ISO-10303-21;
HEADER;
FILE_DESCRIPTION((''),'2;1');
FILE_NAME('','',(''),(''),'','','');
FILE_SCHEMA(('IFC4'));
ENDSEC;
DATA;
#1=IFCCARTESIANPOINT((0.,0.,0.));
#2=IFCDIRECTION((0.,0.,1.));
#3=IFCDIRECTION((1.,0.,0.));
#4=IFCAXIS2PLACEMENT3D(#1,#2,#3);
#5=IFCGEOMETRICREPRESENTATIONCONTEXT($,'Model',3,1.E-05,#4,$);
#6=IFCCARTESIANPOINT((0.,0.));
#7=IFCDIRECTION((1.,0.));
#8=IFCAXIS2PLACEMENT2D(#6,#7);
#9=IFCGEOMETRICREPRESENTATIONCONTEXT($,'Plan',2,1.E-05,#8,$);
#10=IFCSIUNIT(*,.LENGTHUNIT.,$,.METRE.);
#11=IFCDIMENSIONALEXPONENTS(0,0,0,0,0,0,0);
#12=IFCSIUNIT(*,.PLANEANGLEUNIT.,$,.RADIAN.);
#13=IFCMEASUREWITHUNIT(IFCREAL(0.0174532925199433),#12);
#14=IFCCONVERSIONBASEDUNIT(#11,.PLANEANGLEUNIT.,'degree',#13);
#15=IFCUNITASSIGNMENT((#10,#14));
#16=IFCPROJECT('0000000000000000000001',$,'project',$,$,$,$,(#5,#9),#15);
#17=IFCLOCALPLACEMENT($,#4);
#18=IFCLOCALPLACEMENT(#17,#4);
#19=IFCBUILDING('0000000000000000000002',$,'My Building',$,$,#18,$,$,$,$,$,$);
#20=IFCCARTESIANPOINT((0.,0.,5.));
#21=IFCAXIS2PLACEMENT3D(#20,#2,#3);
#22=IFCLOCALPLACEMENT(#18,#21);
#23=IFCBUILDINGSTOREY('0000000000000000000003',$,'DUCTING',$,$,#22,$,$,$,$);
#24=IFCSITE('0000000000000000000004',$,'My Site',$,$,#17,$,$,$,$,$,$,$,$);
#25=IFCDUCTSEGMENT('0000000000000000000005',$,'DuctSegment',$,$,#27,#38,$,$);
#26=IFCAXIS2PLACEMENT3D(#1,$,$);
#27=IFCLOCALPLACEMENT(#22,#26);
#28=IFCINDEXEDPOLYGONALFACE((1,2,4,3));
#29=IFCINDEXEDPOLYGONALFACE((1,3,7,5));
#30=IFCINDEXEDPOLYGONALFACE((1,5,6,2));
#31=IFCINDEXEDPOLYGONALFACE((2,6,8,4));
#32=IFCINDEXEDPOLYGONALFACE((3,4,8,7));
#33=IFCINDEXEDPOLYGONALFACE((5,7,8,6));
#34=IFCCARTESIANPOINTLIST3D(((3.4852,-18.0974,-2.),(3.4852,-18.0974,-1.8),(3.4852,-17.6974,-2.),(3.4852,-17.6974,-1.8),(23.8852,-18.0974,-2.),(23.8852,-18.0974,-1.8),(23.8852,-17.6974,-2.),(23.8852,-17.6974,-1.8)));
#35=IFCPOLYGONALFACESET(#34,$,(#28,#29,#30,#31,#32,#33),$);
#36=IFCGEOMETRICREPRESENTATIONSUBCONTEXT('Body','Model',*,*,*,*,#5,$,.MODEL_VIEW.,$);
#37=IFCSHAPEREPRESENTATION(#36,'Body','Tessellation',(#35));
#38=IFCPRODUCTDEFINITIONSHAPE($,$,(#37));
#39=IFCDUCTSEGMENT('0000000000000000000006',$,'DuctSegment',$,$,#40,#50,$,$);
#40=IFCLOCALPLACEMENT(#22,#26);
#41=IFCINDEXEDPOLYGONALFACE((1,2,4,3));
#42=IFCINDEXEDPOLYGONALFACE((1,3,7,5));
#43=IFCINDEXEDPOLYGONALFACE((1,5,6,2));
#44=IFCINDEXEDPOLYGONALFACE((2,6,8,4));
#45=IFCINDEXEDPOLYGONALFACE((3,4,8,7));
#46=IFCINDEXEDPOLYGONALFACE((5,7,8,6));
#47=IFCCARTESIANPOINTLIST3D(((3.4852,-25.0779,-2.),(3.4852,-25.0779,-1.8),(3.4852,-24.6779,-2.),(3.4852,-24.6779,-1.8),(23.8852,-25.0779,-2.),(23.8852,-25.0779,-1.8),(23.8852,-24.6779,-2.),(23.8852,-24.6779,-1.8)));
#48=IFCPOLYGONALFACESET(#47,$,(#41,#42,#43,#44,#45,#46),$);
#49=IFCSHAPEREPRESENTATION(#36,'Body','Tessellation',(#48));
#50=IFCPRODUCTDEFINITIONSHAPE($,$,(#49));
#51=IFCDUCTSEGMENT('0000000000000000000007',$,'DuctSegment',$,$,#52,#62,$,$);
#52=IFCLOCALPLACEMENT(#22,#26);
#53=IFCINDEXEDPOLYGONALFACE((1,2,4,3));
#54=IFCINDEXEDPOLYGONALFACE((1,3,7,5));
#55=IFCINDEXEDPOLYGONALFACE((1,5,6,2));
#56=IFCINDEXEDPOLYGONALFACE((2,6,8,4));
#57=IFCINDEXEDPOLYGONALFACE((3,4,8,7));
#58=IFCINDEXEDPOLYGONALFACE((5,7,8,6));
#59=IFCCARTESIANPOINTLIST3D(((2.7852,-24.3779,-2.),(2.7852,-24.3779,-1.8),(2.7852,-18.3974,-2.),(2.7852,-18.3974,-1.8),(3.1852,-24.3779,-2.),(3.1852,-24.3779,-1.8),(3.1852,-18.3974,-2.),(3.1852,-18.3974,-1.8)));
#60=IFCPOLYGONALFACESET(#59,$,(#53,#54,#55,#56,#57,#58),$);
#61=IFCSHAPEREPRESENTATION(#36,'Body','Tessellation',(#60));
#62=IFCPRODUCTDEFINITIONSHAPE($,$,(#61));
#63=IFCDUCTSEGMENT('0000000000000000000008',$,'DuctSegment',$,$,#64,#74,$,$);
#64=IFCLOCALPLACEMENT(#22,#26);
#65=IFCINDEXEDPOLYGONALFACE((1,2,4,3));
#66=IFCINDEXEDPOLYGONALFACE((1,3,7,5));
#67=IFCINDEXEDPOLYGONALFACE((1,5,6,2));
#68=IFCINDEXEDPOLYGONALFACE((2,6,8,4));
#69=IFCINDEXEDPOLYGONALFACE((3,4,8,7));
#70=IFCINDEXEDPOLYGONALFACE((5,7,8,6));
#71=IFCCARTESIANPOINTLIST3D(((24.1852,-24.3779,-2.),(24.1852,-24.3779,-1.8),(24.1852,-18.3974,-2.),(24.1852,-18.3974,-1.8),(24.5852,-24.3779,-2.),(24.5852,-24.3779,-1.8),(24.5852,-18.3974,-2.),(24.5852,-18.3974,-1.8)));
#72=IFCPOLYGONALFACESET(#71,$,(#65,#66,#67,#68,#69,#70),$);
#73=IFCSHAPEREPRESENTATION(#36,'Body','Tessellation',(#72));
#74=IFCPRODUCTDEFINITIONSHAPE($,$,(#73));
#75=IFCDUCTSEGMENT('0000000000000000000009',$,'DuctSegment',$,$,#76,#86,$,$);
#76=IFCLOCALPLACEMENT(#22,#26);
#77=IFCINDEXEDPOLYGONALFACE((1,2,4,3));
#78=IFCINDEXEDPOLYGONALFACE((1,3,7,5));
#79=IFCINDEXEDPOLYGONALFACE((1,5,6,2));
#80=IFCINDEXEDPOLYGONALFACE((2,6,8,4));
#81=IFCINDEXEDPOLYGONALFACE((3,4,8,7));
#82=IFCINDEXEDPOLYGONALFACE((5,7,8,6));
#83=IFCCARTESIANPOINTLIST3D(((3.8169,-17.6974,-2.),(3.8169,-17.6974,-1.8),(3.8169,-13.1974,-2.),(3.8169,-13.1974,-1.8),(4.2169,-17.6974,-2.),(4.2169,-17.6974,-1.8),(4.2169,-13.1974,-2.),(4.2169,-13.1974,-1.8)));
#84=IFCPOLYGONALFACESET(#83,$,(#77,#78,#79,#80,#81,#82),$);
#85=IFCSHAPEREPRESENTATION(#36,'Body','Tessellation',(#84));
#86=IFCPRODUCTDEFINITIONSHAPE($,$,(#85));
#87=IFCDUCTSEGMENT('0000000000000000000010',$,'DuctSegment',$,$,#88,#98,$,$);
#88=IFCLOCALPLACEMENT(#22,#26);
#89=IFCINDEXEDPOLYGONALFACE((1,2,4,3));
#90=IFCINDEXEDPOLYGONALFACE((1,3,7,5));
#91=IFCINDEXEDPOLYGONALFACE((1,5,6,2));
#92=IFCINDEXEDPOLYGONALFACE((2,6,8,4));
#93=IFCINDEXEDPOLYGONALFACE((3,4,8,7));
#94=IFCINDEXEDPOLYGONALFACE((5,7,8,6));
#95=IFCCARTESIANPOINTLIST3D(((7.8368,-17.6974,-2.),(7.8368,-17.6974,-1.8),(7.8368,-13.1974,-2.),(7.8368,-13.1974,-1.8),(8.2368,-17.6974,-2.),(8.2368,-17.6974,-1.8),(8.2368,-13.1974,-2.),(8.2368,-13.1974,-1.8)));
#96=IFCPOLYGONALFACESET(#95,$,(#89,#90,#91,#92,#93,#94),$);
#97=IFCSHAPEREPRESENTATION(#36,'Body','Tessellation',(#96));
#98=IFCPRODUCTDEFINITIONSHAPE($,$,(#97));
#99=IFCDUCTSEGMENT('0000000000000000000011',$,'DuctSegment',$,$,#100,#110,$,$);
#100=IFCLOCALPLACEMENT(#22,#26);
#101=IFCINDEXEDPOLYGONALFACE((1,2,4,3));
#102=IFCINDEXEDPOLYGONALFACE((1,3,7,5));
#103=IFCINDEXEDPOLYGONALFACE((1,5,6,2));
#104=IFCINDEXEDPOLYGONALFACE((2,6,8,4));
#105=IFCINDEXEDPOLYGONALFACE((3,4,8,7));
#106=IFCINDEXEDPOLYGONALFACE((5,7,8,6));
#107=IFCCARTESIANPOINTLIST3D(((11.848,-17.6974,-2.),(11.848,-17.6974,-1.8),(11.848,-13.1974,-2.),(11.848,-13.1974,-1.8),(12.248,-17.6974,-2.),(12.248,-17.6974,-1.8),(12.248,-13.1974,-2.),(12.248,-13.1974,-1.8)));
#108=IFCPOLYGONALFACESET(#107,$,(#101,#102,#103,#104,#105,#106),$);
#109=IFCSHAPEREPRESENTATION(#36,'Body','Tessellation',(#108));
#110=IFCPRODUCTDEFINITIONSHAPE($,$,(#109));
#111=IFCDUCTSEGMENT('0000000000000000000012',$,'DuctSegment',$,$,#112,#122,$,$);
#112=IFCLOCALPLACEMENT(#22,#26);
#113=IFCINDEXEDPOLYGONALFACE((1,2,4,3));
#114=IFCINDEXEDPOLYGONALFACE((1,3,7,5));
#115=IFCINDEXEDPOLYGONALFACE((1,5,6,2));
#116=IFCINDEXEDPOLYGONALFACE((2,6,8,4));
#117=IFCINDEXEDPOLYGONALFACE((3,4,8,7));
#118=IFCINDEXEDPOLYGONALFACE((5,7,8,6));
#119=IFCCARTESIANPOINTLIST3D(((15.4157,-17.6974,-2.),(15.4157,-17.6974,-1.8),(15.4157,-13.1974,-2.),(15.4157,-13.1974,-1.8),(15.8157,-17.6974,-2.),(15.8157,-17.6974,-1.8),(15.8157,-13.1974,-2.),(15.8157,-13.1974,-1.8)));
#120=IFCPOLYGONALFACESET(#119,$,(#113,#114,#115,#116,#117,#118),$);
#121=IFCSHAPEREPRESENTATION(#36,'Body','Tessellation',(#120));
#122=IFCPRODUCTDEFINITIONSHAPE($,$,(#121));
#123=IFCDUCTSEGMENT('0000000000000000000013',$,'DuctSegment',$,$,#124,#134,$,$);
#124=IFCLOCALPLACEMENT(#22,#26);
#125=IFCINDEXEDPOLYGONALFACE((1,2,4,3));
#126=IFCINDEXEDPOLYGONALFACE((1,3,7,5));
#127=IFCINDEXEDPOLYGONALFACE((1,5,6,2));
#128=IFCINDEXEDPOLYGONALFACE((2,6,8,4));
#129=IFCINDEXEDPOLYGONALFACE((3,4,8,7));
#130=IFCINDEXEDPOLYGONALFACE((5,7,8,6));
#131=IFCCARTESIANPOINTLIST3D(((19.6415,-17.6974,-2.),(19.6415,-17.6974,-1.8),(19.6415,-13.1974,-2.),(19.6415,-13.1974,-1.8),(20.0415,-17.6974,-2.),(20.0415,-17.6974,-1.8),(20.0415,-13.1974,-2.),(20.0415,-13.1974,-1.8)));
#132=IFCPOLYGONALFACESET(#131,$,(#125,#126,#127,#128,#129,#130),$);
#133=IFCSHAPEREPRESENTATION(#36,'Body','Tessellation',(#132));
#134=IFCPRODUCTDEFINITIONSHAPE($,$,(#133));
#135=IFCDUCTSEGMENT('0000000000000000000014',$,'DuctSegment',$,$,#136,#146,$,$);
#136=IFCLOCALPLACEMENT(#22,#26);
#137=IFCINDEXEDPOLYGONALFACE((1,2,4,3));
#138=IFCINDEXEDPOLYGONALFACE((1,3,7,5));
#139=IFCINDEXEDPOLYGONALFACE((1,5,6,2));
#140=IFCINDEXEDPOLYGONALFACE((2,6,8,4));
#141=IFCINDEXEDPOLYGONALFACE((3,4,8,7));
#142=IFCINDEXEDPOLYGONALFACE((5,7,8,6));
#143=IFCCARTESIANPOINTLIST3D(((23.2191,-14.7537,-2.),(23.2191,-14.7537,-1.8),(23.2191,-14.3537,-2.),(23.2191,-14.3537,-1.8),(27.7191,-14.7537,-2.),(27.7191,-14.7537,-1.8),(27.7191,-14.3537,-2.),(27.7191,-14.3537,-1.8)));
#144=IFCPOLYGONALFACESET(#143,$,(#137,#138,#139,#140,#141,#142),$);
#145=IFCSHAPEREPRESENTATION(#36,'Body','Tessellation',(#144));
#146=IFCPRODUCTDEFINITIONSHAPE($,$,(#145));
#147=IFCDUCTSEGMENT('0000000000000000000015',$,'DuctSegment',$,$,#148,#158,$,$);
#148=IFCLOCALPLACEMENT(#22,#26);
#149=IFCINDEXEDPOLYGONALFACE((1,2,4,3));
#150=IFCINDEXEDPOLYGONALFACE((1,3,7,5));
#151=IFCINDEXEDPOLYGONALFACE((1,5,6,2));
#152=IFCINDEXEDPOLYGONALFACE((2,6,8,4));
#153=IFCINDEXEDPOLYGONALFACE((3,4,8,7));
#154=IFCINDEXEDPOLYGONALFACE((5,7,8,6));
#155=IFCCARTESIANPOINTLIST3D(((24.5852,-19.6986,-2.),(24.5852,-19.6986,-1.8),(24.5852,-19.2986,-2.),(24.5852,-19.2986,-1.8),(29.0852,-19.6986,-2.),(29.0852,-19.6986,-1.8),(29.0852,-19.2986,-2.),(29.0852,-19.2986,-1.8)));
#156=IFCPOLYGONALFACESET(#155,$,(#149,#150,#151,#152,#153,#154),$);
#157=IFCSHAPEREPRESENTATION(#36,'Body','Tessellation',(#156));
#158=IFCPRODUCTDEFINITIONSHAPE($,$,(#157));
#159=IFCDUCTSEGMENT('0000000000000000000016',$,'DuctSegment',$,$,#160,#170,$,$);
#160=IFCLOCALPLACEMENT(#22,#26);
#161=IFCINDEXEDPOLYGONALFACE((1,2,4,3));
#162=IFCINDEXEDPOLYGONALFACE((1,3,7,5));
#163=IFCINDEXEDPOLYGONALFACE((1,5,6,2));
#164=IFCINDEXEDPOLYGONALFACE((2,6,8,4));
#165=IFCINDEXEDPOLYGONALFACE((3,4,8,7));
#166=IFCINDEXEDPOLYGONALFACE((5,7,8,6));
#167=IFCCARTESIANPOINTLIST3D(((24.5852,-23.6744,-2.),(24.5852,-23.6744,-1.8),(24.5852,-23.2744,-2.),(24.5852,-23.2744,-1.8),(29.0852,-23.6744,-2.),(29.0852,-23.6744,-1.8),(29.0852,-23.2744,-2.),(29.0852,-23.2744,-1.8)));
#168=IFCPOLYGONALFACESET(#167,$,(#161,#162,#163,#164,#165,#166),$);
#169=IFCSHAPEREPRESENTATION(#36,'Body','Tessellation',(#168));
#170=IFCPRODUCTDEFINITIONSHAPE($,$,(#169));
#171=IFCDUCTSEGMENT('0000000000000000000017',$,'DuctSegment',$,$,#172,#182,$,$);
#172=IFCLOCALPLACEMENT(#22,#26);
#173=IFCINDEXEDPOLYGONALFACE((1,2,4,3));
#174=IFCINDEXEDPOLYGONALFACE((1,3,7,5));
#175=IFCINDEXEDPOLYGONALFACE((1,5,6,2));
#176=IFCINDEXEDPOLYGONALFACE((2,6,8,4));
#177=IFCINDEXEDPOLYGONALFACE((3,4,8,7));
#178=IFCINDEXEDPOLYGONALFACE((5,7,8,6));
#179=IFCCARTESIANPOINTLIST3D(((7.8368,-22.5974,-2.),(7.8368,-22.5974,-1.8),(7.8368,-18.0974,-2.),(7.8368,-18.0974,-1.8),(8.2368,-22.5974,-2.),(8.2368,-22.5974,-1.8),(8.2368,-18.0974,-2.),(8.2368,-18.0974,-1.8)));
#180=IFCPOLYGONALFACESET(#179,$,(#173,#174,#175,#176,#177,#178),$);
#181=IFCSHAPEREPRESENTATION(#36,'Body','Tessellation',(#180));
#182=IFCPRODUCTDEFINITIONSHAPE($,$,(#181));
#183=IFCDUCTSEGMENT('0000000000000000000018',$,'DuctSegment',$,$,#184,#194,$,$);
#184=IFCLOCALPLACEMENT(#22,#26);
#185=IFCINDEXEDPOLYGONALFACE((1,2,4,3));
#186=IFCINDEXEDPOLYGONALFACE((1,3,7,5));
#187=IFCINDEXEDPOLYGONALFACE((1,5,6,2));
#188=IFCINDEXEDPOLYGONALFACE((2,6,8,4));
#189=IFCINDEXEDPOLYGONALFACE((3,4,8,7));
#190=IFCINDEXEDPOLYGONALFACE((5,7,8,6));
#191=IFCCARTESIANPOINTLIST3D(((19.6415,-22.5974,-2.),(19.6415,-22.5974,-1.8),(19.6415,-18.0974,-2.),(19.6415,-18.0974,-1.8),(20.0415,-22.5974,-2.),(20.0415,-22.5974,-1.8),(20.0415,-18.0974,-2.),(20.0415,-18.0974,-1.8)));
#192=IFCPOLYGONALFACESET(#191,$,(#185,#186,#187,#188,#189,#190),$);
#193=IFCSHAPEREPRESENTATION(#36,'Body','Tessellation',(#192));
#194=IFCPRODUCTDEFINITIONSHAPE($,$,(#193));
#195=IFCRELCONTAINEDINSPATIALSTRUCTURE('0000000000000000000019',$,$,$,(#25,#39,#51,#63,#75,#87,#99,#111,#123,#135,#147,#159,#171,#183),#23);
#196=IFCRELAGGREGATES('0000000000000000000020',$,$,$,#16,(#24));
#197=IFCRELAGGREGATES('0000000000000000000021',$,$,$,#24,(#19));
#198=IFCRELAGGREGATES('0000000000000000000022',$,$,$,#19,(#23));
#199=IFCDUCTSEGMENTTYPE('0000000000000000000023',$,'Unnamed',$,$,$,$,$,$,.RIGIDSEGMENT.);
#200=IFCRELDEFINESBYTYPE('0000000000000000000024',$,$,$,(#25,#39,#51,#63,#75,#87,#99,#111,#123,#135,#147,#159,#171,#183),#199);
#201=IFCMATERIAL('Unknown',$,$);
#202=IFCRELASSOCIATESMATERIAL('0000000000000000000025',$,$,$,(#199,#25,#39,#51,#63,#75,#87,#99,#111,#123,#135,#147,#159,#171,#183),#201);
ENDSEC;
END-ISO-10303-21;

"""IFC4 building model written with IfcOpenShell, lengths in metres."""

from ifc_helpers import new_model, entity, si_unit, converted_unit, frame, origin_with_axes, origin_2d_with_axis, place, context, subcontext, project, spatial, rectangle, extrude, material, material_profile, profile_set, profile_usage, type_object, element, save


model = new_model("IFC4")

# Units and contexts
model_context = context("Model", 3, precision=1e-05, world=origin_with_axes())
plan_context = context("Plan", 2, precision=1e-05, world=origin_2d_with_axis())
body_context = subcontext(model_context, "Body", "Model", "MODEL_VIEW")
ifc_project = project(units=[si_unit("LENGTHUNIT", "METRE"), converted_unit("PLANEANGLEUNIT", "degree", entity("IfcReal", 0.0174532925199433), si_unit("PLANEANGLEUNIT", "RADIAN"), dimensions=[0, 0, 0, 0, 0, 0, 0])], contexts=[model_context, plan_context])

# Site, building, storey
site_placement = place(None, origin_with_axes())
site = spatial("IfcSite", under=ifc_project, at=site_placement, Name="My Site")
building_placement = place(site_placement, origin_with_axes())
building = spatial("IfcBuilding", under=site, at=building_placement, Name="My Building")
storey_placement = place(building_placement, frame((0.0, 0.0, 5.0), z_axis=(0.0, 0.0, 1.0), x_axis=(1.0, 0.0, 0.0)))
storey = spatial("IfcBuildingStorey", under=building, at=storey_placement, Name="DUCTING")

# Duct segments
ifc_material = material(Name="Unknown")
ifc_material_profile = material_profile(ifc_material, rectangle(XDim=0.4, YDim=0.2))
ifc_profile_set = profile_set([ifc_material_profile])
ifc_profile_usage_1 = profile_usage(ifc_profile_set, cardinal=5)
duct_segment_type = type_object("IfcDuctSegmentType", Name="Unnamed", PredefinedType="RIGIDSEGMENT", material=ifc_profile_set)
duct_segment_1_placement = place(storey_placement, frame((3.4852, -17.8974, -1.9), z_axis=(1.0, 0.0, 0.0), x_axis=(0.0, 1.0, 0.0)))
element("IfcDuctSegment", 1, at=duct_segment_1_placement, inside=storey, type_object=duct_segment_type, material=ifc_profile_usage_1, Name="DuctSegment", context=body_context, shape_type="SweptSolid", body=[
    extrude(rectangle(XDim=0.4, YDim=0.2), origin_with_axes(), (0.0, 0.0, 1.0), 20.4),
])
ifc_profile_usage_2 = profile_usage(ifc_profile_set, cardinal=5)
duct_segment_2_placement = place(storey_placement, frame((3.4852, -24.8779, -1.9), z_axis=(1.0, 0.0, 0.0), x_axis=(0.0, 1.0, 0.0)))
element("IfcDuctSegment", 2, at=duct_segment_2_placement, inside=storey, type_object=duct_segment_type, material=ifc_profile_usage_2, Name="DuctSegment", context=body_context, shape_type="SweptSolid", body=[
    extrude(rectangle(XDim=0.4, YDim=0.2), origin_with_axes(), (0.0, 0.0, 1.0), 20.4),
])
ifc_profile_usage_3 = profile_usage(ifc_profile_set, cardinal=5)
duct_segment_3_placement = place(storey_placement, frame((2.9852, -18.3974, -1.9), z_axis=(0.0, -1.0, 0.0), x_axis=(1.0, 0.0, 0.0)))
element("IfcDuctSegment", 3, at=duct_segment_3_placement, inside=storey, type_object=duct_segment_type, material=ifc_profile_usage_3, Name="DuctSegment", context=body_context, shape_type="SweptSolid", body=[
    extrude(rectangle(XDim=0.4, YDim=0.2), origin_with_axes(), (0.0, 0.0, 1.0), 5.9805),
])
ifc_profile_usage_4 = profile_usage(ifc_profile_set, cardinal=5)
duct_segment_4_placement = place(storey_placement, frame((24.3852, -18.3974, -1.9), z_axis=(0.0, -1.0, 0.0), x_axis=(1.0, 0.0, 0.0)))
element("IfcDuctSegment", 4, at=duct_segment_4_placement, inside=storey, type_object=duct_segment_type, material=ifc_profile_usage_4, Name="DuctSegment", context=body_context, shape_type="SweptSolid", body=[
    extrude(rectangle(XDim=0.4, YDim=0.2), origin_with_axes(), (0.0, 0.0, 1.0), 5.9805),
])
ifc_profile_usage_5 = profile_usage(ifc_profile_set, cardinal=5)
duct_segment_5_placement = place(storey_placement, frame((4.0169, -17.6974, -1.9), z_axis=(0.0, 1.0, -0.000003), x_axis=(-1.0, 0.0, 0.0)))
element("IfcDuctSegment", 5, at=duct_segment_5_placement, inside=storey, type_object=duct_segment_type, material=ifc_profile_usage_5, Name="DuctSegment", context=body_context, shape_type="SweptSolid", body=[
    extrude(rectangle(XDim=0.4, YDim=0.2), origin_with_axes(), (0.0, 0.0, 1.0), 4.5),
])
ifc_profile_usage_6 = profile_usage(ifc_profile_set, cardinal=5)
duct_segment_6_placement = place(storey_placement, frame((8.0368, -17.6974, -1.9), z_axis=(0.0, 1.0, -0.000003), x_axis=(-1.0, 0.0, 0.0)))
element("IfcDuctSegment", 6, at=duct_segment_6_placement, inside=storey, type_object=duct_segment_type, material=ifc_profile_usage_6, Name="DuctSegment", context=body_context, shape_type="SweptSolid", body=[
    extrude(rectangle(XDim=0.4, YDim=0.2), origin_with_axes(), (0.0, 0.0, 1.0), 4.5),
])
ifc_profile_usage_7 = profile_usage(ifc_profile_set, cardinal=5)
duct_segment_7_placement = place(storey_placement, frame((12.048, -17.6974, -1.9), z_axis=(0.0, 1.0, -0.000003), x_axis=(-1.0, 0.0, 0.0)))
element("IfcDuctSegment", 7, at=duct_segment_7_placement, inside=storey, type_object=duct_segment_type, material=ifc_profile_usage_7, Name="DuctSegment", context=body_context, shape_type="SweptSolid", body=[
    extrude(rectangle(XDim=0.4, YDim=0.2), origin_with_axes(), (0.0, 0.0, 1.0), 4.5),
])
ifc_profile_usage_8 = profile_usage(ifc_profile_set, cardinal=5)
duct_segment_8_placement = place(storey_placement, frame((15.6157, -17.6974, -1.9), z_axis=(0.0, 1.0, -0.000003), x_axis=(-1.0, 0.0, 0.0)))
element("IfcDuctSegment", 8, at=duct_segment_8_placement, inside=storey, type_object=duct_segment_type, material=ifc_profile_usage_8, Name="DuctSegment", context=body_context, shape_type="SweptSolid", body=[
    extrude(rectangle(XDim=0.4, YDim=0.2), origin_with_axes(), (0.0, 0.0, 1.0), 4.5),
])
ifc_profile_usage_9 = profile_usage(ifc_profile_set, cardinal=5)
duct_segment_9_placement = place(storey_placement, frame((19.8415, -17.6974, -1.9), z_axis=(0.0, 1.0, -0.000003), x_axis=(-1.0, 0.0, 0.0)))
element("IfcDuctSegment", 9, at=duct_segment_9_placement, inside=storey, type_object=duct_segment_type, material=ifc_profile_usage_9, Name="DuctSegment", context=body_context, shape_type="SweptSolid", body=[
    extrude(rectangle(XDim=0.4, YDim=0.2), origin_with_axes(), (0.0, 0.0, 1.0), 4.5),
])
ifc_profile_usage_10 = profile_usage(ifc_profile_set, cardinal=5)
duct_segment_10_placement = place(storey_placement, frame((27.7191, -14.5537, -1.9), z_axis=(-1.0, 0.0, -0.000003), x_axis=(0.0, -1.0, 0.0)))
element("IfcDuctSegment", 10, at=duct_segment_10_placement, inside=storey, type_object=duct_segment_type, material=ifc_profile_usage_10, Name="DuctSegment", context=body_context, shape_type="SweptSolid", body=[
    extrude(rectangle(XDim=0.4, YDim=0.2), origin_with_axes(), (0.0, 0.0, 1.0), 4.5),
])
ifc_profile_usage_11 = profile_usage(ifc_profile_set, cardinal=5)
duct_segment_11_placement = place(storey_placement, frame((29.0852, -19.4986, -1.9), z_axis=(-1.0, 0.0, -0.000003), x_axis=(0.0, -1.0, 0.0)))
element("IfcDuctSegment", 11, at=duct_segment_11_placement, inside=storey, type_object=duct_segment_type, material=ifc_profile_usage_11, Name="DuctSegment", context=body_context, shape_type="SweptSolid", body=[
    extrude(rectangle(XDim=0.4, YDim=0.2), origin_with_axes(), (0.0, 0.0, 1.0), 4.5),
])
ifc_profile_usage_12 = profile_usage(ifc_profile_set, cardinal=5)
duct_segment_12_placement = place(storey_placement, frame((29.0852, -23.4744, -1.9), z_axis=(-1.0, 0.0, -0.000003), x_axis=(0.0, -1.0, 0.0)))
element("IfcDuctSegment", 12, at=duct_segment_12_placement, inside=storey, type_object=duct_segment_type, material=ifc_profile_usage_12, Name="DuctSegment", context=body_context, shape_type="SweptSolid", body=[
    extrude(rectangle(XDim=0.4, YDim=0.2), origin_with_axes(), (0.0, 0.0, 1.0), 4.5),
])
ifc_profile_usage_13 = profile_usage(ifc_profile_set, cardinal=5)
duct_segment_13_placement = place(storey_placement, frame((8.0368, -22.5974, -1.9), z_axis=(0.0, 1.0, -0.000003), x_axis=(-1.0, 0.0, 0.0)))
element("IfcDuctSegment", 13, at=duct_segment_13_placement, inside=storey, type_object=duct_segment_type, material=ifc_profile_usage_13, Name="DuctSegment", context=body_context, shape_type="SweptSolid", body=[
    extrude(rectangle(XDim=0.4, YDim=0.2), origin_with_axes(), (0.0, 0.0, 1.0), 4.5),
])
ifc_profile_usage_14 = profile_usage(ifc_profile_set, cardinal=5)
duct_segment_14_placement = place(storey_placement, frame((19.8415, -22.5974, -1.9), z_axis=(0.0, 1.0, -0.000003), x_axis=(-1.0, 0.0, 0.0)))
element("IfcDuctSegment", 14, at=duct_segment_14_placement, inside=storey, type_object=duct_segment_type, material=ifc_profile_usage_14, Name="DuctSegment", context=body_context, shape_type="SweptSolid", body=[
    extrude(rectangle(XDim=0.4, YDim=0.2), origin_with_axes(), (0.0, 0.0, 1.0), 4.5),
])

save(model, "model.ifc")
